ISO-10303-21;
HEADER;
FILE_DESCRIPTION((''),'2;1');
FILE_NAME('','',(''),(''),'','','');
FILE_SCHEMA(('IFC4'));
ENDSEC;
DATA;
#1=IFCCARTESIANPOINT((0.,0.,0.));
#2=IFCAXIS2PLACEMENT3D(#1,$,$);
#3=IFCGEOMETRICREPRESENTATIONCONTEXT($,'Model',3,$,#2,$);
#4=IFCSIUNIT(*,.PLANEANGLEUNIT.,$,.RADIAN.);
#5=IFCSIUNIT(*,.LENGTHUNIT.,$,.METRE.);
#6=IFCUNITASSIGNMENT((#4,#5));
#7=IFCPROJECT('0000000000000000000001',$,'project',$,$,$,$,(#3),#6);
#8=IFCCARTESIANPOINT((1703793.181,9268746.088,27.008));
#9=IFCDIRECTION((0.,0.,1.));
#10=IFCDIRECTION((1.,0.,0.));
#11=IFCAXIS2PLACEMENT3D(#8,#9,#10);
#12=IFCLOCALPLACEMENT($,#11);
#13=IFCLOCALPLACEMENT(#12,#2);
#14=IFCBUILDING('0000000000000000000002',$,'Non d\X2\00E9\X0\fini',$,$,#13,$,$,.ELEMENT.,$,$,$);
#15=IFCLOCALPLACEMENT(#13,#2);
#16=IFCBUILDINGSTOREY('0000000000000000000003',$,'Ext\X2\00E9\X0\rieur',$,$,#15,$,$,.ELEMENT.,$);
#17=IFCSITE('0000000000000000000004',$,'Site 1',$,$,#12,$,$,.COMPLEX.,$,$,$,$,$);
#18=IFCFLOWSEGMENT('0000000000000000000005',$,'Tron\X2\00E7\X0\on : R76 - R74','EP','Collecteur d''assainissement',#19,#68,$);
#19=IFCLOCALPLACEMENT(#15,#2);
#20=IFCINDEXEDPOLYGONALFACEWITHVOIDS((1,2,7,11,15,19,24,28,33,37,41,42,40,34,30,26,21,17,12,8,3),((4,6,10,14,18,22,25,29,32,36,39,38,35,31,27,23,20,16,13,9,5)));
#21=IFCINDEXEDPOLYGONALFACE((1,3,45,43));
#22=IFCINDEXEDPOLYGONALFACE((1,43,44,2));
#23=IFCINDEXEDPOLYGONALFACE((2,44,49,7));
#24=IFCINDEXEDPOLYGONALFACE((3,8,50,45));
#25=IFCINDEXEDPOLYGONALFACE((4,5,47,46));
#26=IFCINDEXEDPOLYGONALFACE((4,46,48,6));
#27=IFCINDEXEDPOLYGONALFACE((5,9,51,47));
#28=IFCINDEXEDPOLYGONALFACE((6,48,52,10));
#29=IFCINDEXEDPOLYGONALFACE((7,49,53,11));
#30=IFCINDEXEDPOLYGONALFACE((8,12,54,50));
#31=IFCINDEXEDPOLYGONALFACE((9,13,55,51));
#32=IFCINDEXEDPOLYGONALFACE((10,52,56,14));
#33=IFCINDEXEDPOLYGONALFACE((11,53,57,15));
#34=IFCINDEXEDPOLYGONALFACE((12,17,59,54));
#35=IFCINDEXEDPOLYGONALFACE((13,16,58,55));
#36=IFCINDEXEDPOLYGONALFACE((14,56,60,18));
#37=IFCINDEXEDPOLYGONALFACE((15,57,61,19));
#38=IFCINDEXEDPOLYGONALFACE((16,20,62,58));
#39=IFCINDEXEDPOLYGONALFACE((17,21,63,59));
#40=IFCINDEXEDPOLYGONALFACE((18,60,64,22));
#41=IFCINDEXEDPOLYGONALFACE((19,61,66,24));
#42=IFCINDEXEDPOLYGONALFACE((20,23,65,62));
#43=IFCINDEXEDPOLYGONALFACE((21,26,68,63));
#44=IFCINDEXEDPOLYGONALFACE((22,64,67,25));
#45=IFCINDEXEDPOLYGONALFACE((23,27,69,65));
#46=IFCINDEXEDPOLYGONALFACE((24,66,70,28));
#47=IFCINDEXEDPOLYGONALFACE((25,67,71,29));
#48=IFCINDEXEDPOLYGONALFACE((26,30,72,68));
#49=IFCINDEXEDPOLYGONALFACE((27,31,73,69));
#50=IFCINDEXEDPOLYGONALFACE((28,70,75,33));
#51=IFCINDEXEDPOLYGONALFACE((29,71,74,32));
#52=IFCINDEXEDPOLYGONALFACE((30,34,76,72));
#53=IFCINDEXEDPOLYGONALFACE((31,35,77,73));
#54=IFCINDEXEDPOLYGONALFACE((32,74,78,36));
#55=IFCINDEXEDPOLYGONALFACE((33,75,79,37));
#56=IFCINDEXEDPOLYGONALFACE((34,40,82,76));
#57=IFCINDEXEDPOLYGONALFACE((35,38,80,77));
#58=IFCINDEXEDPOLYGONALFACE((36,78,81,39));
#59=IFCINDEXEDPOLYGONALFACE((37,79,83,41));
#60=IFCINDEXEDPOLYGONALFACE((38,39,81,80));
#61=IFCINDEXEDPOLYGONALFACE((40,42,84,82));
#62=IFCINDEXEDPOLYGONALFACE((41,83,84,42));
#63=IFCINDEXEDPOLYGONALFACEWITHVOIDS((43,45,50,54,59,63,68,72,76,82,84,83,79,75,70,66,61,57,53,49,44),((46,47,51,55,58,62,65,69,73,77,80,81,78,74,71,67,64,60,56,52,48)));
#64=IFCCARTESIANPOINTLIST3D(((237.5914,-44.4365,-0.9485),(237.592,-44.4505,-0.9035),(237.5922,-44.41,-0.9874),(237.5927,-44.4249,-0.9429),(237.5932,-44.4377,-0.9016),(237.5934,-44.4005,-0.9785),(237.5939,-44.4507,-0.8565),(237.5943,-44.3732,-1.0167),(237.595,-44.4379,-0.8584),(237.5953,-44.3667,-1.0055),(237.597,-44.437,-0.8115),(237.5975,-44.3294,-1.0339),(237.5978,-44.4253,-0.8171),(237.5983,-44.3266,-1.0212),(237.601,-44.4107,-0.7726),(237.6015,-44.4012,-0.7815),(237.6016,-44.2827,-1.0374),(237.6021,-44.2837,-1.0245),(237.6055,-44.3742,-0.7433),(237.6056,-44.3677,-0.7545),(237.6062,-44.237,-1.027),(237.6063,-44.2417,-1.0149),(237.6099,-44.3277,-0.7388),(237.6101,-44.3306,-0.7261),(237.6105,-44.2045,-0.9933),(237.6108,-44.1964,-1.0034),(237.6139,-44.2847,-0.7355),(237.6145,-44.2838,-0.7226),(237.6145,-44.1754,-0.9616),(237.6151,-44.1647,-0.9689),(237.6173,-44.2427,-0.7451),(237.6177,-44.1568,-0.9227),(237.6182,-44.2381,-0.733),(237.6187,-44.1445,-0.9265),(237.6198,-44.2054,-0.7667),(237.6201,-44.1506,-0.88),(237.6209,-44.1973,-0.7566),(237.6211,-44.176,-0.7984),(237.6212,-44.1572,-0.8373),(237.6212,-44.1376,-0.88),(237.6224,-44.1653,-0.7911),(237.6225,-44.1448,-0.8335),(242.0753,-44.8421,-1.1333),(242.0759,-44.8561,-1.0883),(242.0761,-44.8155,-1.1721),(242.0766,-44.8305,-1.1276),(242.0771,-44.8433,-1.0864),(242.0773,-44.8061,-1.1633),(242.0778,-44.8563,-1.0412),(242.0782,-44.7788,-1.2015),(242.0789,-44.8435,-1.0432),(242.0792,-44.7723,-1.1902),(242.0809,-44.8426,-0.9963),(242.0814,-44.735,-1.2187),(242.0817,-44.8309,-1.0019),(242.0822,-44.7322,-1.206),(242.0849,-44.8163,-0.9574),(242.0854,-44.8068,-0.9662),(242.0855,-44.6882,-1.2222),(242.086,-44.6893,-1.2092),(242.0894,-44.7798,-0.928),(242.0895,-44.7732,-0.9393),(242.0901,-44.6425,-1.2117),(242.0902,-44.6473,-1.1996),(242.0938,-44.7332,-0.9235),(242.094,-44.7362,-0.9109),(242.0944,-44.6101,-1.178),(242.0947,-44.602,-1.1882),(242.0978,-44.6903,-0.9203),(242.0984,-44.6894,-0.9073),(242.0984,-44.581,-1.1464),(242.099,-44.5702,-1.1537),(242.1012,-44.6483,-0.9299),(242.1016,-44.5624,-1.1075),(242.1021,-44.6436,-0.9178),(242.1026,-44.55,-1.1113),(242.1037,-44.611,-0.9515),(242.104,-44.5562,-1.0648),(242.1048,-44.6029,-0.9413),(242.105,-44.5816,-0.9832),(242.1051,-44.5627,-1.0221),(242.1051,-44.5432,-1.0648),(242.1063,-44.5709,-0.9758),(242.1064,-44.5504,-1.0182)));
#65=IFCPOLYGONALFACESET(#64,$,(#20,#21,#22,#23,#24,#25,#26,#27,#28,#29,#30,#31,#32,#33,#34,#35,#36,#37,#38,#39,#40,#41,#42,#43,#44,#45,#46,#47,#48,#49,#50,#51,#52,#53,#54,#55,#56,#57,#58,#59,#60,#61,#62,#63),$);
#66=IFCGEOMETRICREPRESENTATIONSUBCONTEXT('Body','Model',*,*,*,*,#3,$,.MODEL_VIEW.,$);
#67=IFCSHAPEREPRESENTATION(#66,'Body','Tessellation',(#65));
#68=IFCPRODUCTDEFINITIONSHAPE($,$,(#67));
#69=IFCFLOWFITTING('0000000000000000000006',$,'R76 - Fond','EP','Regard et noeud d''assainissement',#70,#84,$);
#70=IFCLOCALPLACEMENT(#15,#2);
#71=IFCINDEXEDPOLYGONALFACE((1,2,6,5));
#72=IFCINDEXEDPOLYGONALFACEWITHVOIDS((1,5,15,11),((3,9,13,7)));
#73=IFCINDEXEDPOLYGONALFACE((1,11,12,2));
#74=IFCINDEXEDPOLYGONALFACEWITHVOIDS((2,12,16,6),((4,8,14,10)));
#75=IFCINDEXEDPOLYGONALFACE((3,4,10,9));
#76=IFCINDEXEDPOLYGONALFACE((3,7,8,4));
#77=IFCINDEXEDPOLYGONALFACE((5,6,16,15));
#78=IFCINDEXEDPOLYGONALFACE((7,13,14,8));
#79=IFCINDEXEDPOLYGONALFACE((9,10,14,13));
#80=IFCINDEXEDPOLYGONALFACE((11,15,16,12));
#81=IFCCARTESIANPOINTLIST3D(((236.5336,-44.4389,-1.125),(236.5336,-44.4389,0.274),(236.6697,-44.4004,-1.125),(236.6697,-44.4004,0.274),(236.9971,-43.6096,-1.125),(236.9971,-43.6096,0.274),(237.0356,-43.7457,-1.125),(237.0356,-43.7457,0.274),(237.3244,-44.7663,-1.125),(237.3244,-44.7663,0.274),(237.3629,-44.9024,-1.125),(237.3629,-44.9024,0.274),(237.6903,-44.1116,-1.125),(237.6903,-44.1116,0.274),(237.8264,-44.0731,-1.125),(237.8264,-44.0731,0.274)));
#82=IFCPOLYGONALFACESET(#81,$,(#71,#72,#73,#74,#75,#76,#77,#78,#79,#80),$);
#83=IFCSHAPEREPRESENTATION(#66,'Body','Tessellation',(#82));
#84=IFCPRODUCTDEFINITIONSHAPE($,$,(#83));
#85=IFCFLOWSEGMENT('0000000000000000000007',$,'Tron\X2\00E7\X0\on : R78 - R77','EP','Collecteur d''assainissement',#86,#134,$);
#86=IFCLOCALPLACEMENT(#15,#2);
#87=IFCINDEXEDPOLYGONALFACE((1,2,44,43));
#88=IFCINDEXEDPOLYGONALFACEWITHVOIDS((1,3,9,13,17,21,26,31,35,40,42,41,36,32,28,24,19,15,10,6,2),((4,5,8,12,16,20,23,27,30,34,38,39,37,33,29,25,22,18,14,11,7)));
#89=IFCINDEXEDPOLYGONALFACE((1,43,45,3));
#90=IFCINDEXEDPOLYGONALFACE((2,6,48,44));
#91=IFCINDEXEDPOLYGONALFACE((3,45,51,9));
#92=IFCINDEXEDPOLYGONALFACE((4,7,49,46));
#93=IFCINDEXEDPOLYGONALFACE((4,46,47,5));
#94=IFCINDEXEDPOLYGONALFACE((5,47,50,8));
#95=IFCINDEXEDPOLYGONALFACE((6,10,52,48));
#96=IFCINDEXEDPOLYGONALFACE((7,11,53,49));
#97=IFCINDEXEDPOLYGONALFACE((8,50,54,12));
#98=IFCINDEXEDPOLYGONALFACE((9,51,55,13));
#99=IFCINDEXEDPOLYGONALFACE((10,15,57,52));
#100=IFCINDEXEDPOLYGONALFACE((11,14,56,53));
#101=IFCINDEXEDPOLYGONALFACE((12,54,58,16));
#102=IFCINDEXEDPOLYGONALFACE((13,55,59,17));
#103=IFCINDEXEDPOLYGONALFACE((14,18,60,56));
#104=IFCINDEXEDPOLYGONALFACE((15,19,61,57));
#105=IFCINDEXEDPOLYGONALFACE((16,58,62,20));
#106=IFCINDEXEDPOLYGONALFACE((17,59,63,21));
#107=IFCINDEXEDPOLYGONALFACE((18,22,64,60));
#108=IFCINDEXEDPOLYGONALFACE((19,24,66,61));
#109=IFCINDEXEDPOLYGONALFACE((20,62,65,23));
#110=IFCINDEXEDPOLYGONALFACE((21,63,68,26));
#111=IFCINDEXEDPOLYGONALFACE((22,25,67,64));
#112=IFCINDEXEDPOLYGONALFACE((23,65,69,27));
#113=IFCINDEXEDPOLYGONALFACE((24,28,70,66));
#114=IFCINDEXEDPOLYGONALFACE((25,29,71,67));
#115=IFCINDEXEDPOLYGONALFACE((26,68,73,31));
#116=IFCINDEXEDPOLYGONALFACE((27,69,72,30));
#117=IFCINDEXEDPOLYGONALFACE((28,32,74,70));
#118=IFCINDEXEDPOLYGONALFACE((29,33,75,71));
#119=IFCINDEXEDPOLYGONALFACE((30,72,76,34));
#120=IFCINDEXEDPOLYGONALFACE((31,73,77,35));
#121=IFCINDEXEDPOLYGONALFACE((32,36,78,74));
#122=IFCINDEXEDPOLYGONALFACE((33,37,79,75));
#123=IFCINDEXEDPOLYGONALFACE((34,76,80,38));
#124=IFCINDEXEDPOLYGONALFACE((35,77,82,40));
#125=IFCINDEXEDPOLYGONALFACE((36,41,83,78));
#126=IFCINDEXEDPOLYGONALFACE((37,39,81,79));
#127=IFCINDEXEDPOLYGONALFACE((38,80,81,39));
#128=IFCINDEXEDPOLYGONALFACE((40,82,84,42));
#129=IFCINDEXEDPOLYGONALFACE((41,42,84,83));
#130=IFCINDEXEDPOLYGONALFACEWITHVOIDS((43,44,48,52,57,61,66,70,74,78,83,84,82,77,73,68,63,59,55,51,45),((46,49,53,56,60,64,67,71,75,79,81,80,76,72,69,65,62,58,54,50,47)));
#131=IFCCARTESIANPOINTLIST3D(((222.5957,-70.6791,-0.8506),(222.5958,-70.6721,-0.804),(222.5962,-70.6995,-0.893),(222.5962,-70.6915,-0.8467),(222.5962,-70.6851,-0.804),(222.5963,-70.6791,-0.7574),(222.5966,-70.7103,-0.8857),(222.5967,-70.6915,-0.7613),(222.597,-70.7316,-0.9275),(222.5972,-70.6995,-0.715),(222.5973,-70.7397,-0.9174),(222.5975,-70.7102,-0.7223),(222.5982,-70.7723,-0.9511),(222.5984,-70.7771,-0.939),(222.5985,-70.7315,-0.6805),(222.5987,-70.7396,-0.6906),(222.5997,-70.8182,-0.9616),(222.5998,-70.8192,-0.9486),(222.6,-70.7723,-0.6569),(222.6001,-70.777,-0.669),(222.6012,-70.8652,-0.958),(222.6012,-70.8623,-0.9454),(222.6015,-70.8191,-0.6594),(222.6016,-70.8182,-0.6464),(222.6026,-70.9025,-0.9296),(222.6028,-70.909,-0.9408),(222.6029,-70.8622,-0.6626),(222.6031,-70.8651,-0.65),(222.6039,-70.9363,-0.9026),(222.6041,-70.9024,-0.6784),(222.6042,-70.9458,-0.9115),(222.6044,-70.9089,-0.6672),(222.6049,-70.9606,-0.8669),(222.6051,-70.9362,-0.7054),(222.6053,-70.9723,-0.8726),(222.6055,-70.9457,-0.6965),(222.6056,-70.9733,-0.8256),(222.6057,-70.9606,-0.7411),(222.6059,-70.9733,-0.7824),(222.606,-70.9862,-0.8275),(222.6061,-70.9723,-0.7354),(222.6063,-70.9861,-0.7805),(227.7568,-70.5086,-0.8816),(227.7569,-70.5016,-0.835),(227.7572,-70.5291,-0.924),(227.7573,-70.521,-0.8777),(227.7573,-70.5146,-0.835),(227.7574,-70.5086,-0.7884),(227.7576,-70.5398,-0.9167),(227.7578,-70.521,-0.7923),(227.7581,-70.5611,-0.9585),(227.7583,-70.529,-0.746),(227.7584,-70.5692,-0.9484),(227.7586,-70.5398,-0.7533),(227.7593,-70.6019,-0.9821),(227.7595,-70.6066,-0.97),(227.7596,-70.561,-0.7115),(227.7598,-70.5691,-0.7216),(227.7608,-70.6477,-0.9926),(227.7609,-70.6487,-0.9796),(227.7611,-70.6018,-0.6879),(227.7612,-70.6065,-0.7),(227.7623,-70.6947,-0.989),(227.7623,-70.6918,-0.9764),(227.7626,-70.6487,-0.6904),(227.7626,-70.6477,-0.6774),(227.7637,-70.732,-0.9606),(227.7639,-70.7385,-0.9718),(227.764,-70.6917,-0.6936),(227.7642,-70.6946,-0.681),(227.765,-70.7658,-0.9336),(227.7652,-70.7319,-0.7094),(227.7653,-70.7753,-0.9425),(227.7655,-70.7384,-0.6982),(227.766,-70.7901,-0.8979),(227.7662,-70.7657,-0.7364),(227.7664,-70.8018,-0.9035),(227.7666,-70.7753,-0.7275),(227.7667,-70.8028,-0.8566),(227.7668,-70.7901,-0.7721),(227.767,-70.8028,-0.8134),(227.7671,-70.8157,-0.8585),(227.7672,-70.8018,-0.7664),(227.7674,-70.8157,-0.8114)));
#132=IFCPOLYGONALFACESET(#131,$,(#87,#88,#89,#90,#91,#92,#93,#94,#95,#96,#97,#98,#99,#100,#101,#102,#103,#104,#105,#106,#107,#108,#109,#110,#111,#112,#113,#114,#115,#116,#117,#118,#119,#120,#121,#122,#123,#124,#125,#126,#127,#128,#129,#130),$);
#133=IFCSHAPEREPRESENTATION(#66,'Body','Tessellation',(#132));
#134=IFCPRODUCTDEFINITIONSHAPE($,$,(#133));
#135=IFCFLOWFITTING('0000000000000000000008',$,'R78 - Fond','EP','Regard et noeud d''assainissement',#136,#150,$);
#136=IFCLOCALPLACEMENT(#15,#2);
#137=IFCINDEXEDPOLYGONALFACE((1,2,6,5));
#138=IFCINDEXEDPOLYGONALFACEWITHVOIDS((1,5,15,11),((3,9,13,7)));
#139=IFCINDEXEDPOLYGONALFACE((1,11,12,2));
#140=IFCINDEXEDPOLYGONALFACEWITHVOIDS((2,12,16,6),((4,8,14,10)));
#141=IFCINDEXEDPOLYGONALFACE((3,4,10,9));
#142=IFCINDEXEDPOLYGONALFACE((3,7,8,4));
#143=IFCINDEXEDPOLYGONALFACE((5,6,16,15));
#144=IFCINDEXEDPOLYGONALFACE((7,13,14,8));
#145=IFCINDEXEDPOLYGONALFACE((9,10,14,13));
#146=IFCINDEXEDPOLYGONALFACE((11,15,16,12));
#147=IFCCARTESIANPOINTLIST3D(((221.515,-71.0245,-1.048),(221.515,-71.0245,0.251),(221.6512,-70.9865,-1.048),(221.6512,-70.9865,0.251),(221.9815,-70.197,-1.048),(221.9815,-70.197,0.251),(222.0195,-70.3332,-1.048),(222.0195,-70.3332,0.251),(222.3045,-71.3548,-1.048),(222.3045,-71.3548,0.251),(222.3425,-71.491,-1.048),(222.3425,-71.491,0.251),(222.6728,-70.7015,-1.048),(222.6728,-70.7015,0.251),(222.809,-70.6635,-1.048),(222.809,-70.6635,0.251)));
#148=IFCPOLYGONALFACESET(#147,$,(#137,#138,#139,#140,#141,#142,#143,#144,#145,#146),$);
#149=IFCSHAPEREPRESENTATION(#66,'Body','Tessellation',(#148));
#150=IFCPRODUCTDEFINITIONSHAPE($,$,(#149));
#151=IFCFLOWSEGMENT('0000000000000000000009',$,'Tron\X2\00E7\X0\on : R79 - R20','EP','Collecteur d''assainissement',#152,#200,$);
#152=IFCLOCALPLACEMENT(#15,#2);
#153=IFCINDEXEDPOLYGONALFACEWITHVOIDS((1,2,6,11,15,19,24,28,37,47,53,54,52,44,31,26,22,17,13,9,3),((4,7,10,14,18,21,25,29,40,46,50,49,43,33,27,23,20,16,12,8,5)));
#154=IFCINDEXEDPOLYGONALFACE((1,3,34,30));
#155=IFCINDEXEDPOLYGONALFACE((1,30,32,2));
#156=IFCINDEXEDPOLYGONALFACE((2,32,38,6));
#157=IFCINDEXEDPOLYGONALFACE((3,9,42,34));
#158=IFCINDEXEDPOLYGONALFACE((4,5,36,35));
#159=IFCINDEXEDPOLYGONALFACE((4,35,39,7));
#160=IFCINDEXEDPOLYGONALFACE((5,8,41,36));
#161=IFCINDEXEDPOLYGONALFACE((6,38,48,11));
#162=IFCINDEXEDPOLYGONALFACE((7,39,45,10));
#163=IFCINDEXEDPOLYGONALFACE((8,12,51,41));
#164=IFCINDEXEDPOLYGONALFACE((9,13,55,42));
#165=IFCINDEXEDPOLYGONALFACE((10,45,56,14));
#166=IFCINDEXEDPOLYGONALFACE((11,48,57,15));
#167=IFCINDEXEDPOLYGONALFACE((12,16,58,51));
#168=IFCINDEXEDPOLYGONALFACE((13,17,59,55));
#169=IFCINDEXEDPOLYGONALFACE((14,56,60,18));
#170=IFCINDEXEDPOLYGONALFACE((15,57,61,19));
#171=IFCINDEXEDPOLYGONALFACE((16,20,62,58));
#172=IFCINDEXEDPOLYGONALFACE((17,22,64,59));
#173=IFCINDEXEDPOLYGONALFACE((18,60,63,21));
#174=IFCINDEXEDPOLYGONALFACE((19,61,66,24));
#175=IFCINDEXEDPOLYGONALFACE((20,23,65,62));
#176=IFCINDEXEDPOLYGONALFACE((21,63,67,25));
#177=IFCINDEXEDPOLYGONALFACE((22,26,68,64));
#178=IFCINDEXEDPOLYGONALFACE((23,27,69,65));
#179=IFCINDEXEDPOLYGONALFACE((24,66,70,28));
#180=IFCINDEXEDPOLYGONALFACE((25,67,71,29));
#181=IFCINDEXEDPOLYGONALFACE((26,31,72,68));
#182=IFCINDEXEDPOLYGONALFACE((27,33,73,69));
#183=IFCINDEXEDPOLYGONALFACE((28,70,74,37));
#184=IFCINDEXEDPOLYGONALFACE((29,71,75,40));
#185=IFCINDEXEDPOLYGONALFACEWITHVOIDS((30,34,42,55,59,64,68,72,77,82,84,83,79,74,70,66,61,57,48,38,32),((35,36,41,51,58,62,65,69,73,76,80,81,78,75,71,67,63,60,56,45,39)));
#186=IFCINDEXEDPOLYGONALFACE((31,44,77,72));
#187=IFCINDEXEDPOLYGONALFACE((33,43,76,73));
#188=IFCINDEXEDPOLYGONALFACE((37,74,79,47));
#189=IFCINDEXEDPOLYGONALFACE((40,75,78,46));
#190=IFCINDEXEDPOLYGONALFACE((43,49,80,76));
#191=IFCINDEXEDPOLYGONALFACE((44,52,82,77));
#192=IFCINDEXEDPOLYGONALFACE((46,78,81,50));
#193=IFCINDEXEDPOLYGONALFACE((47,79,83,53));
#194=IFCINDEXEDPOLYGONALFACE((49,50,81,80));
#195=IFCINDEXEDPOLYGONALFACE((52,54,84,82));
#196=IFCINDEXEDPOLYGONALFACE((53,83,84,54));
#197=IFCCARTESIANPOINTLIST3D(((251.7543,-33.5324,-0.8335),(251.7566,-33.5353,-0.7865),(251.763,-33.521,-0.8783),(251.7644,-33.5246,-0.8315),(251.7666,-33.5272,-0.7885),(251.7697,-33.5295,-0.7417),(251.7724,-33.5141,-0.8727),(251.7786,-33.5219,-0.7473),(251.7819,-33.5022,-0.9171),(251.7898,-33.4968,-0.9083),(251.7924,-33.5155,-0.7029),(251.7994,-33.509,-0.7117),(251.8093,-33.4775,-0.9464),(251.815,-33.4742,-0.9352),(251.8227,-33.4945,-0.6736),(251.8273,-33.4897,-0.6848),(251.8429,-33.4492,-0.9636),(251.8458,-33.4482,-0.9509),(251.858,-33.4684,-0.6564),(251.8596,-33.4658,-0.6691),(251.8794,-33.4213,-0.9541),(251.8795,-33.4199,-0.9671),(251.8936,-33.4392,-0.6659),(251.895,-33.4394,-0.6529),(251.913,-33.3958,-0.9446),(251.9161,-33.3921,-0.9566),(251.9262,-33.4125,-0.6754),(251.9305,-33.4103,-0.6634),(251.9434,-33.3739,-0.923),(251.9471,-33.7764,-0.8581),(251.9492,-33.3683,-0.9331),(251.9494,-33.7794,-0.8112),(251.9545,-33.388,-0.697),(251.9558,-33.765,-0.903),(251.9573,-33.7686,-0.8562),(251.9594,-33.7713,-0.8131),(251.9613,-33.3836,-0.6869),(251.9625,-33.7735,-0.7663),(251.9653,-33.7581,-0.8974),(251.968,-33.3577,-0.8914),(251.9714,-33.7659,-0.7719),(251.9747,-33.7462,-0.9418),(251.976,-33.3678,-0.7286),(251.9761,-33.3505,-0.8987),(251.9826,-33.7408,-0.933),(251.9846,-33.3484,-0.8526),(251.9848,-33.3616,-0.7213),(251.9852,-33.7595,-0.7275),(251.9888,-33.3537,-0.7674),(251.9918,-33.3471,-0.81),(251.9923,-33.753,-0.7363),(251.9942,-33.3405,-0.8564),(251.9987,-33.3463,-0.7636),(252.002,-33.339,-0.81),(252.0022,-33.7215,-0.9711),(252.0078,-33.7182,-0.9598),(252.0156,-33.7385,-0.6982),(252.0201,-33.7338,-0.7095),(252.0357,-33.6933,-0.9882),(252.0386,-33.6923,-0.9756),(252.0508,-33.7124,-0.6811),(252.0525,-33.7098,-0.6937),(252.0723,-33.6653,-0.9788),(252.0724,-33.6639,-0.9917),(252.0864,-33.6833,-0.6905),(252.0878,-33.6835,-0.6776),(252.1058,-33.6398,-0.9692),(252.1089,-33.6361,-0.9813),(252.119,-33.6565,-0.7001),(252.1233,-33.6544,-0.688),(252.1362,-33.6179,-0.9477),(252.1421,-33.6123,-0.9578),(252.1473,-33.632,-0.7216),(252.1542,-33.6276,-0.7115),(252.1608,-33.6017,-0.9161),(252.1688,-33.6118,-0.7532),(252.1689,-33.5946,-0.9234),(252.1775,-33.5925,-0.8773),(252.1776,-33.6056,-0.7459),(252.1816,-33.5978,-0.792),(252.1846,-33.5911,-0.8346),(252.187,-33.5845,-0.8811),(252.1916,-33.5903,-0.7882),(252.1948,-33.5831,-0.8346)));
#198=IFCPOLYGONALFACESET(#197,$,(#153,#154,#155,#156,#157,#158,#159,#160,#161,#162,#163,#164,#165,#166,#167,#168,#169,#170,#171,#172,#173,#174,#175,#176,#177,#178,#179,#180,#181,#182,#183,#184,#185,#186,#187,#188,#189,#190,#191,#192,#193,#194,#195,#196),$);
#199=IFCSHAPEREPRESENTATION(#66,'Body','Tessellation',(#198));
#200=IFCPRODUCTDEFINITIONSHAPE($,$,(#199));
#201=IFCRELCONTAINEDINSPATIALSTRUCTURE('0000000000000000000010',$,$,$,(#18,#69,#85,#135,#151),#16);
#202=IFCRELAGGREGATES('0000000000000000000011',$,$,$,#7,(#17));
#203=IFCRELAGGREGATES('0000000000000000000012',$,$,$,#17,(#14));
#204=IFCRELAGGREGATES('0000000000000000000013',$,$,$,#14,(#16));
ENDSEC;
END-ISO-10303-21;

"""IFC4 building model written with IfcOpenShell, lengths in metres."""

from ifc_helpers import new_model, si_unit, frame, origin, origin_2d, place, context, subcontext, project, spatial, hollow_rectangle, hollow_circle, extrude, element, save


model = new_model("IFC4")

# Units and contexts
model_context = context("Model", 3, world=origin())
body_context = subcontext(model_context, "Body", "Model", "MODEL_VIEW")
ifc_project = project(units=[si_unit("PLANEANGLEUNIT", "RADIAN"), si_unit("LENGTHUNIT", "METRE")], contexts=[model_context])

# Site, building, storey
site_placement = place(None, frame((1703793.181, 9268746.088, 27.008), z_axis=(0.0, 0.0, 1.0), x_axis=(1.0, 0.0, 0.0)))
site = spatial("IfcSite", under=ifc_project, at=site_placement, Name="Site 1", CompositionType="COMPLEX")
building_placement = place(site_placement, origin())
building = spatial("IfcBuilding", under=site, at=building_placement, Name="Non défini", CompositionType="ELEMENT")
storey_placement = place(building_placement, origin())
storey = spatial("IfcBuildingStorey", under=building, at=storey_placement, Name="Extérieur", CompositionType="ELEMENT")

# Flow segment
flow_segment_1_placement = place(storey_placement, origin())
element("IfcFlowSegment", 1, at=flow_segment_1_placement, inside=storey, Name="Tronçon : R76 - R74", Description="EP", ObjectType="Collecteur d'assainissement", context=body_context, shape_type="SweptSolid", body=[
    extrude(hollow_circle(Radius=0.158, WallThickness=0.013, at=origin_2d()), frame((237.607, -44.295, -0.88), z_axis=(0.995, -0.09, -0.041), x_axis=(0.09, 0.996, 0.0)), (0.0, 0.0, 1.0), 4.506),
])

# Flow fitting
flow_fitting_1_placement = place(storey_placement, origin())
element("IfcFlowFitting", 2, at=flow_fitting_1_placement, inside=storey, Name="R76 - Fond", Description="EP", ObjectType="Regard et noeud d'assainissement", context=body_context, shape_type="SweptSolid", body=[
    extrude(hollow_rectangle(XDim=0.95, YDim=0.95, WallThickness=0.1, at=origin_2d()), frame((237.18, -44.256, -1.125), z_axis=(0.0, 0.0, 1.0), x_axis=(-0.873, 0.488, 0.0)), (0.0, 0.0, 1.0), 1.399),
])

# Flow segment
flow_segment_2_placement = place(storey_placement, origin())
element("IfcFlowSegment", 3, at=flow_segment_2_placement, inside=storey, Name="Tronçon : R78 - R77", Description="EP", ObjectType="Collecteur d'assainissement", context=body_context, shape_type="SweptSolid", body=[
    extrude(hollow_circle(Radius=0.158, WallThickness=0.013, at=origin_2d()), frame((222.601, -70.83, -0.804), z_axis=(0.999, 0.033, -0.006), x_axis=(-0.033, 0.999, 0.0)), (0.0, 0.0, 1.0), 5.164),
])

# Flow fitting
flow_fitting_2_placement = place(storey_placement, origin())
element("IfcFlowFitting", 4, at=flow_fitting_2_placement, inside=storey, Name="R78 - Fond", Description="EP", ObjectType="Regard et noeud d'assainissement", context=body_context, shape_type="SweptSolid", body=[
    extrude(hollow_rectangle(XDim=0.95, YDim=0.95, WallThickness=0.1, at=origin_2d()), frame((222.162, -70.844, -1.048), z_axis=(0.0, 0.0, 1.0), x_axis=(0.871, -0.491, 0.0)), (0.0, 0.0, 1.0), 1.299),
])

# Flow segment
flow_segment_3_placement = place(storey_placement, origin())
element("IfcFlowSegment", 5, at=flow_segment_3_placement, inside=storey, Name="Tronçon : R79 - R20", Description="EP", ObjectType="Collecteur d'assainissement", context=body_context, shape_type="SweptSolid", body=[
    extrude(hollow_circle(Radius=0.158, WallThickness=0.013, at=origin_2d()), frame((251.878, -33.437, -0.81), z_axis=(0.618, -0.782, -0.079), x_axis=(0.785, 0.62, 0.0)), (0.0, 0.0, 1.0), 0.312),
])

save(model, "model.ifc")
